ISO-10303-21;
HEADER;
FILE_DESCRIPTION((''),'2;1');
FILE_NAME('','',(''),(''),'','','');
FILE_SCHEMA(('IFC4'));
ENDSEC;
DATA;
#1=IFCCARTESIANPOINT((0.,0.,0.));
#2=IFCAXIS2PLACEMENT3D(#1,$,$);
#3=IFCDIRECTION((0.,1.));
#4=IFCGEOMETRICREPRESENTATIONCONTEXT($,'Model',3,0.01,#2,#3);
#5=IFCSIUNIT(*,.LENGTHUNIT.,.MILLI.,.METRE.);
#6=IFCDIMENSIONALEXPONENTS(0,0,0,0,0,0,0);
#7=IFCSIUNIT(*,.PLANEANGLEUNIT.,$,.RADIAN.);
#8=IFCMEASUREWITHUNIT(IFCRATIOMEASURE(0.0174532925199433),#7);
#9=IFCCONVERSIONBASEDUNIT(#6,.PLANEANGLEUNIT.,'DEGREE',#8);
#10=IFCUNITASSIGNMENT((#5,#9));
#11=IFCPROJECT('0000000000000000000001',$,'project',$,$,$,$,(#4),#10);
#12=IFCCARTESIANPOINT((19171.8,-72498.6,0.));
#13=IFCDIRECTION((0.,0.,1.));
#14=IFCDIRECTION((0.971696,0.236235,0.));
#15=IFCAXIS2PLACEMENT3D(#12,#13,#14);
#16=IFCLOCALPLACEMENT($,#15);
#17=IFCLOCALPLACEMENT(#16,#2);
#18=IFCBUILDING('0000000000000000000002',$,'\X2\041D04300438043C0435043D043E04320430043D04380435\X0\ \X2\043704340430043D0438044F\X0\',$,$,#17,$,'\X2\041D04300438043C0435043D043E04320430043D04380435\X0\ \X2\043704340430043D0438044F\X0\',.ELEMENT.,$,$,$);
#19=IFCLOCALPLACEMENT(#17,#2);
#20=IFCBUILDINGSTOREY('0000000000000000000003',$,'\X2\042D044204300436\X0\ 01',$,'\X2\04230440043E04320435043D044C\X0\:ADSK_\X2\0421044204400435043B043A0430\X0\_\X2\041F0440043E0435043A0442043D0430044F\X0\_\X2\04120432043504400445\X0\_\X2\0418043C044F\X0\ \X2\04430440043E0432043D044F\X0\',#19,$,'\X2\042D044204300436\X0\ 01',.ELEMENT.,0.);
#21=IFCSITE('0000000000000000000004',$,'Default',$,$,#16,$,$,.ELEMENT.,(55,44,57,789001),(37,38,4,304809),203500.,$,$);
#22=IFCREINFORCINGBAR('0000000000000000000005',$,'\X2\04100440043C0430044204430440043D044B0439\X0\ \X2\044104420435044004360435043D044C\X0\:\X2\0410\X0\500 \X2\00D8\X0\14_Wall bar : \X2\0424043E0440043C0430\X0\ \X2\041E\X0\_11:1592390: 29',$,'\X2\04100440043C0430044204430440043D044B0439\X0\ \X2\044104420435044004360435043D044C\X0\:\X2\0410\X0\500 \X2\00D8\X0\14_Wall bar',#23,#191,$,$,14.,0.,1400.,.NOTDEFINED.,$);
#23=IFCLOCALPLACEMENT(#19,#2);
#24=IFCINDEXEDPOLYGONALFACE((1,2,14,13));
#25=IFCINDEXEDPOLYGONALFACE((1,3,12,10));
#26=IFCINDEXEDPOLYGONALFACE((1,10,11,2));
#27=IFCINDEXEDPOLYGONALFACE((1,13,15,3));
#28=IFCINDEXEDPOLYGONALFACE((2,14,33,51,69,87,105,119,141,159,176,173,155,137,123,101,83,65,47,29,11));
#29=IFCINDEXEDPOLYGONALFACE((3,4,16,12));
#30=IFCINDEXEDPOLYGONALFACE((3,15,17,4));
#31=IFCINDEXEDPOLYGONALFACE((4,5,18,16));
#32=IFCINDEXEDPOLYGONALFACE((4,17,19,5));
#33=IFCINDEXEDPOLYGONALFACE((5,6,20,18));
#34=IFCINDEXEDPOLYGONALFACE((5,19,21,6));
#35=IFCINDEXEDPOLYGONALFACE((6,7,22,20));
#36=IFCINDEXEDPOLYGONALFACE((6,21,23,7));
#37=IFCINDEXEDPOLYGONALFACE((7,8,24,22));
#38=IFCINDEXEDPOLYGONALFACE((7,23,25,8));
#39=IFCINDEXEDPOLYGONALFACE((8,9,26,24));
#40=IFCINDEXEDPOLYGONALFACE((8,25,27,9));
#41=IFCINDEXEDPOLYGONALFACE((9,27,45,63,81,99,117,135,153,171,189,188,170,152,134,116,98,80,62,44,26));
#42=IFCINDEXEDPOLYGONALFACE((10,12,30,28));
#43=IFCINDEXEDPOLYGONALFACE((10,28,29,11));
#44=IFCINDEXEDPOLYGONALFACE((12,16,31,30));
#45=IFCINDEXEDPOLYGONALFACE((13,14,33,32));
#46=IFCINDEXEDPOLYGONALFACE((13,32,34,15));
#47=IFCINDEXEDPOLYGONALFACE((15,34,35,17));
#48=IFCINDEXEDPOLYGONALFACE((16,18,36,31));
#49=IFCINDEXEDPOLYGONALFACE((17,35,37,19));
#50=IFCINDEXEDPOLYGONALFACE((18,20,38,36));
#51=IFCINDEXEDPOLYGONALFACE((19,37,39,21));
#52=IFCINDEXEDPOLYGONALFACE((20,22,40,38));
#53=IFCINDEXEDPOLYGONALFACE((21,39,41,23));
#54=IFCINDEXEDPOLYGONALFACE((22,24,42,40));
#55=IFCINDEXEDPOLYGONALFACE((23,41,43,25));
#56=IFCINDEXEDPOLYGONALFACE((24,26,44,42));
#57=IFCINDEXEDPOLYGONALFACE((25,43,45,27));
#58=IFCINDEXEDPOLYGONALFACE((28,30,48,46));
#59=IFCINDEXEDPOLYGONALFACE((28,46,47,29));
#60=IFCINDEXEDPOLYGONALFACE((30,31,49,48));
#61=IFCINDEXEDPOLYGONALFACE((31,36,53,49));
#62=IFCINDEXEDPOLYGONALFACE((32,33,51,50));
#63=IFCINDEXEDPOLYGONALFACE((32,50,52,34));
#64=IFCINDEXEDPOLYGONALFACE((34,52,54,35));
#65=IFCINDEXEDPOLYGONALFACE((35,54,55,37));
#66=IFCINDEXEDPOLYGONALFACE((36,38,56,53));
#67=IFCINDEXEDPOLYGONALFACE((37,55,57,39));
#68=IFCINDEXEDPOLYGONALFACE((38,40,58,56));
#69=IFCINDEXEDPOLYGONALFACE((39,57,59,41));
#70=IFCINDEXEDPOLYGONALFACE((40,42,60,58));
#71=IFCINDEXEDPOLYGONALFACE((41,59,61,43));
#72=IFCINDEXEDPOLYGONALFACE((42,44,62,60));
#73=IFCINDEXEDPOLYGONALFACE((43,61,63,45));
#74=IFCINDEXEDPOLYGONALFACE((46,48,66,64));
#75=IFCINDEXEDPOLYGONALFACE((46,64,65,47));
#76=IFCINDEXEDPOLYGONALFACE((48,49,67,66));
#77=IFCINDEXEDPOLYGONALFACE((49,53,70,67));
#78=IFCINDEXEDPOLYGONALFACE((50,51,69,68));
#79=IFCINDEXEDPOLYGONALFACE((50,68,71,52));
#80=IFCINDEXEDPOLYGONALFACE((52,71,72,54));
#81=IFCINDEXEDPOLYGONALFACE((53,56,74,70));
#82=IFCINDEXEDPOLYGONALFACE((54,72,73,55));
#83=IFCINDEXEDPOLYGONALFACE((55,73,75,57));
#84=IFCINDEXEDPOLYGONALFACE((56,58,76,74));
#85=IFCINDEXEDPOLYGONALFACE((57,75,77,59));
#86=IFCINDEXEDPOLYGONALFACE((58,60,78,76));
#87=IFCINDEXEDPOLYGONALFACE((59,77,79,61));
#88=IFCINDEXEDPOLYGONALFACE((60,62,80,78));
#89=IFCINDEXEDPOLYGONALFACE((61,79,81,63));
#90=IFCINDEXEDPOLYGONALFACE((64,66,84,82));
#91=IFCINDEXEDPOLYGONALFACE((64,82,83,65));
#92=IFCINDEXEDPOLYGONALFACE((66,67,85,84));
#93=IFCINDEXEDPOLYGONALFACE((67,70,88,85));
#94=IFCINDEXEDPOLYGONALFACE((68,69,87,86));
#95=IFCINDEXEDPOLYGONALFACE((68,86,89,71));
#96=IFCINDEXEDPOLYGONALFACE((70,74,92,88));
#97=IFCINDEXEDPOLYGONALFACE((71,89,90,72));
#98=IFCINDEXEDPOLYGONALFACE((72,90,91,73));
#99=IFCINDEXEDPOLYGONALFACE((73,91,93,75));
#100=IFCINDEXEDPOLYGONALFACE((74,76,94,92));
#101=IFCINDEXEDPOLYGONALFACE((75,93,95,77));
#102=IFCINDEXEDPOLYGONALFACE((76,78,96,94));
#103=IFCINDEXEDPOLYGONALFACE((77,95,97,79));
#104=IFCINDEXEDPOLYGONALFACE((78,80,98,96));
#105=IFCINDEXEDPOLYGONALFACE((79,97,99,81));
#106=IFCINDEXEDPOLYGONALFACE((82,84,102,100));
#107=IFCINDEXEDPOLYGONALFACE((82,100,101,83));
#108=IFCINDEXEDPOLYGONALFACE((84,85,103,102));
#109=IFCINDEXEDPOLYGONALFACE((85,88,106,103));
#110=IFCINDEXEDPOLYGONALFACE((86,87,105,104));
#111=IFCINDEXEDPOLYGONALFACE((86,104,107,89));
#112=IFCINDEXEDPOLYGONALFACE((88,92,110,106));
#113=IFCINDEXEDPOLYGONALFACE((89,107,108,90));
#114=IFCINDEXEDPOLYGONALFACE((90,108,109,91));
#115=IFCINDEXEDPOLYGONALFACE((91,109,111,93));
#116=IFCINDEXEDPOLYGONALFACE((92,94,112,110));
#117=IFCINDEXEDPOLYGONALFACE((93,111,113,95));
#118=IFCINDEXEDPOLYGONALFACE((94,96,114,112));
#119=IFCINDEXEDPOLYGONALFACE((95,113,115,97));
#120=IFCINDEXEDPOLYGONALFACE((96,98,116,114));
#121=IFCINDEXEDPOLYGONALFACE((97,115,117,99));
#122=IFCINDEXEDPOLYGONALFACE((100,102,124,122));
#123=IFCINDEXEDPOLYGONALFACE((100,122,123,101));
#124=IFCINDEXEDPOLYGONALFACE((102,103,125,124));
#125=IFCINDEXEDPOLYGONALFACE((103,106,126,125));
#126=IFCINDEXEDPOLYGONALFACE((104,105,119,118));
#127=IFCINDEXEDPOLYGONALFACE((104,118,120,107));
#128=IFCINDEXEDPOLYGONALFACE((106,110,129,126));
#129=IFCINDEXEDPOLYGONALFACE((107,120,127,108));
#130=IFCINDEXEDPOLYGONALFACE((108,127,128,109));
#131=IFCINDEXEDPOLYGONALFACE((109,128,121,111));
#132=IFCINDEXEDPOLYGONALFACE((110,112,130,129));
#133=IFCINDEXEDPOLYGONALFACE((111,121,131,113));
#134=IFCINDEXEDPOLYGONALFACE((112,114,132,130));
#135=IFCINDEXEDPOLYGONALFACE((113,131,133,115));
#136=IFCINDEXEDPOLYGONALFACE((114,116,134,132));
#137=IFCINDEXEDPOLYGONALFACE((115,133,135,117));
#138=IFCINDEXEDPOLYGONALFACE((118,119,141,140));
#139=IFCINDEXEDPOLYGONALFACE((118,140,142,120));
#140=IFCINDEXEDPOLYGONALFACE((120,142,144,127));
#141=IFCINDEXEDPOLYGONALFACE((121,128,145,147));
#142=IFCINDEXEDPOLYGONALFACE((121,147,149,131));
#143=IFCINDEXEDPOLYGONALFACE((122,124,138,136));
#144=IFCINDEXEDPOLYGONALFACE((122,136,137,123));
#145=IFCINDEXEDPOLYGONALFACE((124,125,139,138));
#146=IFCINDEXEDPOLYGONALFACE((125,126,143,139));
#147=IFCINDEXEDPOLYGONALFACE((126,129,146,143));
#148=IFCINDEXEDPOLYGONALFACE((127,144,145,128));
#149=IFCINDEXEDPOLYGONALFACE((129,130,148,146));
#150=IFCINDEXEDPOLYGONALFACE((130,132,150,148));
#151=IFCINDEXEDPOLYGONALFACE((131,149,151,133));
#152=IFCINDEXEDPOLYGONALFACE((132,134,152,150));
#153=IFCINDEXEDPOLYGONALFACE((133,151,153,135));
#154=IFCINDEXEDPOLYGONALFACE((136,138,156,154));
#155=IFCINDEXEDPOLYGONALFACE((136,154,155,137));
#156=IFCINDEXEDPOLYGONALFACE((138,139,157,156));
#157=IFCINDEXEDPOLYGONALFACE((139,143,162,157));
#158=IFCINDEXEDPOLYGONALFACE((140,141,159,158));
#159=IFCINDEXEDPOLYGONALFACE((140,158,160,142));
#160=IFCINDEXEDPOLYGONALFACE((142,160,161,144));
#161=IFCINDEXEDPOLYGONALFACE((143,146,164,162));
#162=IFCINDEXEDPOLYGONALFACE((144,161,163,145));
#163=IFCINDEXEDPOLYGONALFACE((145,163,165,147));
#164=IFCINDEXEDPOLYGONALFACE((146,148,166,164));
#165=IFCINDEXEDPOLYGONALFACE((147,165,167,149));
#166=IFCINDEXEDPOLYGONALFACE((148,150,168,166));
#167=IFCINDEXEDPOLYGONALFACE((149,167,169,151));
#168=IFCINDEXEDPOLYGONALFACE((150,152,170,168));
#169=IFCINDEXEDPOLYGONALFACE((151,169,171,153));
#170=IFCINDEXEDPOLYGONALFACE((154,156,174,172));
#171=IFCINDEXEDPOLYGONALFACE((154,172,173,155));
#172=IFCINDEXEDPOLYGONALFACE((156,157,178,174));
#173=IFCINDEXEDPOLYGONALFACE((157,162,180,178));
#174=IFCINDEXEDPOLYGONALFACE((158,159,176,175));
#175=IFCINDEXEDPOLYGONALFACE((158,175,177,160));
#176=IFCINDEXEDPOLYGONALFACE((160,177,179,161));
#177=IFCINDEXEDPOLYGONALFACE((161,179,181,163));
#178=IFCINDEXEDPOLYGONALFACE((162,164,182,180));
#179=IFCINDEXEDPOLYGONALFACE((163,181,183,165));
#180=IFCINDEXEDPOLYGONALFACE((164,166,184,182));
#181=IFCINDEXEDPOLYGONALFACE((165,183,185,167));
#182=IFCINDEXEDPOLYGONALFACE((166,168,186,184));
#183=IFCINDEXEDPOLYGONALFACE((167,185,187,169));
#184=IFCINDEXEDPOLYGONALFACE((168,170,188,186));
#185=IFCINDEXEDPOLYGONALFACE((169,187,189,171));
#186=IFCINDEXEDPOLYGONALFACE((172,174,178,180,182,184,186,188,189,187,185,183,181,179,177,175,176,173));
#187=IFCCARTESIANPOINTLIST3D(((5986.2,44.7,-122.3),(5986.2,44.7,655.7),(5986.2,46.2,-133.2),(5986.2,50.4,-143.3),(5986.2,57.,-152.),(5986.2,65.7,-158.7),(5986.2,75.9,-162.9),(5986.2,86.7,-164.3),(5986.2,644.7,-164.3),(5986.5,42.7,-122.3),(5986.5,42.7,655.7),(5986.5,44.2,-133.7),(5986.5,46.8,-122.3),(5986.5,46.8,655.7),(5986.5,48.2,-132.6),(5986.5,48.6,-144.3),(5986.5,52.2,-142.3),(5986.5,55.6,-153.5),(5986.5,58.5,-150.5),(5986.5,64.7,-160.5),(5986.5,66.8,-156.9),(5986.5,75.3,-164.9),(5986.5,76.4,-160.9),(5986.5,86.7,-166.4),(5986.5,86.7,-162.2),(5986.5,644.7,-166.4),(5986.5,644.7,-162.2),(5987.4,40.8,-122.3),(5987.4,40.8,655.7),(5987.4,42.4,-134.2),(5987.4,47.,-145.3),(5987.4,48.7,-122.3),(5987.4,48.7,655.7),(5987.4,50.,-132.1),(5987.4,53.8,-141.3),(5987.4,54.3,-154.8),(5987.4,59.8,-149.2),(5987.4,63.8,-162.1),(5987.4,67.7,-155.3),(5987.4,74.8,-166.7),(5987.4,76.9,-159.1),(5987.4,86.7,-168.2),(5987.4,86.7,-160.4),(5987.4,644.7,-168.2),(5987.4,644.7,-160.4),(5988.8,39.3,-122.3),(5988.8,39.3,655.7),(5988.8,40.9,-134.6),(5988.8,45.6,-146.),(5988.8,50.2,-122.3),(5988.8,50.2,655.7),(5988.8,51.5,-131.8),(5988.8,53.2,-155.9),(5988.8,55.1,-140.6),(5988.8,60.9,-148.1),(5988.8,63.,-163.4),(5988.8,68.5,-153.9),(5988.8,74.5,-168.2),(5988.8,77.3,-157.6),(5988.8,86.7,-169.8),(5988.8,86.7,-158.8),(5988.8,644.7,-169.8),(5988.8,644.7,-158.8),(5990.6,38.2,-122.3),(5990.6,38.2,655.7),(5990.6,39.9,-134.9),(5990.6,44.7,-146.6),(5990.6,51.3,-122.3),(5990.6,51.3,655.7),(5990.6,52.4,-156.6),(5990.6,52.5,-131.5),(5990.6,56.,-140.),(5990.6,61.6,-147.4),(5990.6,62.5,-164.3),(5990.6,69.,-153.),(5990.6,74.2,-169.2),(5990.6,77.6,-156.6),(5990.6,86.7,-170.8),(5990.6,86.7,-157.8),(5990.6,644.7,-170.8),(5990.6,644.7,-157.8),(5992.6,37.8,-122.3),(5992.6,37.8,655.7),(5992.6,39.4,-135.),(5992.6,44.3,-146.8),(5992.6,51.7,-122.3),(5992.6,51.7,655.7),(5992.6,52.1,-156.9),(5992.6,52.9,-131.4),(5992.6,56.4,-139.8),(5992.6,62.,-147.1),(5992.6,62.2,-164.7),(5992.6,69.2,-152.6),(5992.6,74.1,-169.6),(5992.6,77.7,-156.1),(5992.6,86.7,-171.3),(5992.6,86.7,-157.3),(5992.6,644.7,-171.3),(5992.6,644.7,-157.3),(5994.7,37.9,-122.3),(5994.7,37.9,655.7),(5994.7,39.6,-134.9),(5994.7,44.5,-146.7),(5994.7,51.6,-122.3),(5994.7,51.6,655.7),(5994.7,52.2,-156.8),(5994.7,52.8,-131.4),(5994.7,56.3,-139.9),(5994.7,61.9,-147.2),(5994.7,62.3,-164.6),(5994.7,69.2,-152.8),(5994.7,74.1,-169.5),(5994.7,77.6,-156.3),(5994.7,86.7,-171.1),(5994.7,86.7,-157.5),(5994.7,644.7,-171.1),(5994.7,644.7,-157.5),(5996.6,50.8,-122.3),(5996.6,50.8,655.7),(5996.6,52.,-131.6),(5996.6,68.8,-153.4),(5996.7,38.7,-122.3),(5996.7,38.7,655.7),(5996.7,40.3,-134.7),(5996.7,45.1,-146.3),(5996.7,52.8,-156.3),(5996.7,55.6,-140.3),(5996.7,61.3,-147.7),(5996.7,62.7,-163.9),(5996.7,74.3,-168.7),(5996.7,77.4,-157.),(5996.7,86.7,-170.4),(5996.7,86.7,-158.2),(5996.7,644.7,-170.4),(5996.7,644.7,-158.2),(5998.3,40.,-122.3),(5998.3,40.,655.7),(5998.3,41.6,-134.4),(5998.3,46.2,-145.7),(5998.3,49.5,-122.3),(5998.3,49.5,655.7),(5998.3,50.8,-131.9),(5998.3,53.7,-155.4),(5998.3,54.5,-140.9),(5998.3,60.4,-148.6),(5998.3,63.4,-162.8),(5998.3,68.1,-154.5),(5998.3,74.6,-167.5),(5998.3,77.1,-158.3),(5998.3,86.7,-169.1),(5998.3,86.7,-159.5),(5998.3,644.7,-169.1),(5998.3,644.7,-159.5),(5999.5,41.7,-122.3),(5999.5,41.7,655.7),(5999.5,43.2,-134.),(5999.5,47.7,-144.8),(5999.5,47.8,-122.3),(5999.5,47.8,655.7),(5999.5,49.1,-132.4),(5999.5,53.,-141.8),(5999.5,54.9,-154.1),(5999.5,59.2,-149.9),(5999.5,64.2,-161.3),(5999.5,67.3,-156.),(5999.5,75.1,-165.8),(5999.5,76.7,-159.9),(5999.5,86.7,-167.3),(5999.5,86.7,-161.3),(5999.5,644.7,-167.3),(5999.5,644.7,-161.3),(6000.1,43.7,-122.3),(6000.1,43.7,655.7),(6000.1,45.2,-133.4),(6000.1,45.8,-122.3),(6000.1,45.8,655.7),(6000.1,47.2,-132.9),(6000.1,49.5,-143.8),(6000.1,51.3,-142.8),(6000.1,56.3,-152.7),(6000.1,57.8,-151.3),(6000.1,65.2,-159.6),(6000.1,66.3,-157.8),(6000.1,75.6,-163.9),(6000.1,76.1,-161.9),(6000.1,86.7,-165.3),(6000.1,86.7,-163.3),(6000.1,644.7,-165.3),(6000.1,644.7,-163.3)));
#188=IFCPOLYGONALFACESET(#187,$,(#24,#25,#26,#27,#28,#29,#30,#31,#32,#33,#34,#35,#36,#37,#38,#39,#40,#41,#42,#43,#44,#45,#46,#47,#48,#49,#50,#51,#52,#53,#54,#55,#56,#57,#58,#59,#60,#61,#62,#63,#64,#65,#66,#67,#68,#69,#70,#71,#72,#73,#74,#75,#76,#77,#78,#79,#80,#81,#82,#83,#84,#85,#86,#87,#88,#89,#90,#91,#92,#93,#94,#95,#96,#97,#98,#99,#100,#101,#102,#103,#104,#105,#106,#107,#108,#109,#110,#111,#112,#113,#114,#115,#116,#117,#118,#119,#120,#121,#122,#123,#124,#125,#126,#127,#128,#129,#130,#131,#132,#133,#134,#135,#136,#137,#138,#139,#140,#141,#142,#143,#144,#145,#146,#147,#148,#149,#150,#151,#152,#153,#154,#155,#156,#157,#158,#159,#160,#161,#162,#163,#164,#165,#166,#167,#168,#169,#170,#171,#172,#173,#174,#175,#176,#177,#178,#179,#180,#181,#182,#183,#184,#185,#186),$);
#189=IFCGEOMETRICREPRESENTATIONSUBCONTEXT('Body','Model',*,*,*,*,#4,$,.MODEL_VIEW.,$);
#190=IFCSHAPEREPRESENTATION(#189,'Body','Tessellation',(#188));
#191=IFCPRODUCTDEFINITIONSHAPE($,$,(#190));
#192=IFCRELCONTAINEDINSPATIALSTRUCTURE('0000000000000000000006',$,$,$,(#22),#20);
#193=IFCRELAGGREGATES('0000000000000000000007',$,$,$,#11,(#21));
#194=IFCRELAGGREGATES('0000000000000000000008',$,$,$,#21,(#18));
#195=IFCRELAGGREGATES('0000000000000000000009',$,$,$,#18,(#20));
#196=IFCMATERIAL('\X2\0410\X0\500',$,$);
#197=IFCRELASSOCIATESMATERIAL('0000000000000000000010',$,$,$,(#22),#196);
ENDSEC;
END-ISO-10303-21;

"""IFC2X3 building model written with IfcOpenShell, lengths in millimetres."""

from ifc_helpers import new_model, entity, si_unit, converted_unit, direction, frame, origin, place, context, subcontext, project, spatial, material, element, save


model = new_model("IFC2X3")

# Units and contexts
model_context = context("Model", 3, precision=0.01, world=origin(), true_north=direction((0.0, 1.0)))
body_context = subcontext(model_context, "Body", "Model", "MODEL_VIEW")
ifc_project = project(units=[si_unit("LENGTHUNIT", "METRE", prefix="MILLI"), converted_unit("PLANEANGLEUNIT", "DEGREE", entity("IfcRatioMeasure", 0.0174532925199433), si_unit("PLANEANGLEUNIT", "RADIAN"), dimensions=[0, 0, 0, 0, 0, 0, 0])], contexts=[model_context])

# Site, building, storey
site_placement = place(None, frame((19171.8, -72498.6, 0.0), z_axis=(0.0, 0.0, 1.0), x_axis=(0.971696, 0.236235, 0.0)))
site = spatial("IfcSite", under=ifc_project, at=site_placement, Name="Default", CompositionType="ELEMENT", RefLatitude=(55, 44, 57, 789001), RefLongitude=(37, 38, 4, 304809), RefElevation=203500.0)
building_placement = place(site_placement, origin())
building = spatial("IfcBuilding", under=site, at=building_placement, Name="Наименование здания", LongName="Наименование здания", CompositionType="ELEMENT")
storey_placement = place(building_placement, origin())
storey = spatial("IfcBuildingStorey", under=building, at=storey_placement, Name="Этаж 01", ObjectType="Уровень:ADSK_Стрелка_Проектная_Вверх_Имя уровня", LongName="Этаж 01", CompositionType="ELEMENT", Elevation=0.0)

# Reinforcing bar
ifc_material = material(Name="А500")
placement = place(storey_placement, origin())
element("IfcReinforcingBar", 1, at=placement, inside=storey, material=ifc_material, Name="Арматурный стержень:А500 Ø14_Wall bar : Форма О_11:1592390: 29", ObjectType="Арматурный стержень:А500 Ø14_Wall bar", BarLength=1400.0, BarRole="NOTDEFINED", CrossSectionArea=0.0, NominalDiameter=14.0, context=body_context, shape_type="AdvancedSweptSolid", body=[
    entity("IfcSweptDiskSolid", entity("IfcCompositeCurve", [entity("IfcCompositeCurveSegment", "CONTINUOUS", True, entity("IfcPolyline", [entity("IfcCartesianPoint", [5993.1, 44.7, 655.7]), entity("IfcCartesianPoint", [5993.1, 44.7, -122.3])])), entity("IfcCompositeCurveSegment", "CONTINUOUS", True, entity("IfcTrimmedCurve", entity("IfcCircle", entity("IfcAxis2Placement3D", entity("IfcCartesianPoint", [5993.1, 86.7, -122.3]), entity("IfcDirection", [1.0, 0.0, 0.0]), entity("IfcDirection", [0.0, 0.0, -1.0])), 42.0), [entity("IfcParameterValue", 270.0)], [entity("IfcParameterValue", 360.0)], True, "PARAMETER")), entity("IfcCompositeCurveSegment", "CONTINUOUS", True, entity("IfcPolyline", [entity("IfcCartesianPoint", [5993.1, 86.7, -164.3]), entity("IfcCartesianPoint", [5993.1, 644.7, -164.3])]))], False), 7.0, None, 0.0, 92.0),
])

save(model, "model.ifc")
